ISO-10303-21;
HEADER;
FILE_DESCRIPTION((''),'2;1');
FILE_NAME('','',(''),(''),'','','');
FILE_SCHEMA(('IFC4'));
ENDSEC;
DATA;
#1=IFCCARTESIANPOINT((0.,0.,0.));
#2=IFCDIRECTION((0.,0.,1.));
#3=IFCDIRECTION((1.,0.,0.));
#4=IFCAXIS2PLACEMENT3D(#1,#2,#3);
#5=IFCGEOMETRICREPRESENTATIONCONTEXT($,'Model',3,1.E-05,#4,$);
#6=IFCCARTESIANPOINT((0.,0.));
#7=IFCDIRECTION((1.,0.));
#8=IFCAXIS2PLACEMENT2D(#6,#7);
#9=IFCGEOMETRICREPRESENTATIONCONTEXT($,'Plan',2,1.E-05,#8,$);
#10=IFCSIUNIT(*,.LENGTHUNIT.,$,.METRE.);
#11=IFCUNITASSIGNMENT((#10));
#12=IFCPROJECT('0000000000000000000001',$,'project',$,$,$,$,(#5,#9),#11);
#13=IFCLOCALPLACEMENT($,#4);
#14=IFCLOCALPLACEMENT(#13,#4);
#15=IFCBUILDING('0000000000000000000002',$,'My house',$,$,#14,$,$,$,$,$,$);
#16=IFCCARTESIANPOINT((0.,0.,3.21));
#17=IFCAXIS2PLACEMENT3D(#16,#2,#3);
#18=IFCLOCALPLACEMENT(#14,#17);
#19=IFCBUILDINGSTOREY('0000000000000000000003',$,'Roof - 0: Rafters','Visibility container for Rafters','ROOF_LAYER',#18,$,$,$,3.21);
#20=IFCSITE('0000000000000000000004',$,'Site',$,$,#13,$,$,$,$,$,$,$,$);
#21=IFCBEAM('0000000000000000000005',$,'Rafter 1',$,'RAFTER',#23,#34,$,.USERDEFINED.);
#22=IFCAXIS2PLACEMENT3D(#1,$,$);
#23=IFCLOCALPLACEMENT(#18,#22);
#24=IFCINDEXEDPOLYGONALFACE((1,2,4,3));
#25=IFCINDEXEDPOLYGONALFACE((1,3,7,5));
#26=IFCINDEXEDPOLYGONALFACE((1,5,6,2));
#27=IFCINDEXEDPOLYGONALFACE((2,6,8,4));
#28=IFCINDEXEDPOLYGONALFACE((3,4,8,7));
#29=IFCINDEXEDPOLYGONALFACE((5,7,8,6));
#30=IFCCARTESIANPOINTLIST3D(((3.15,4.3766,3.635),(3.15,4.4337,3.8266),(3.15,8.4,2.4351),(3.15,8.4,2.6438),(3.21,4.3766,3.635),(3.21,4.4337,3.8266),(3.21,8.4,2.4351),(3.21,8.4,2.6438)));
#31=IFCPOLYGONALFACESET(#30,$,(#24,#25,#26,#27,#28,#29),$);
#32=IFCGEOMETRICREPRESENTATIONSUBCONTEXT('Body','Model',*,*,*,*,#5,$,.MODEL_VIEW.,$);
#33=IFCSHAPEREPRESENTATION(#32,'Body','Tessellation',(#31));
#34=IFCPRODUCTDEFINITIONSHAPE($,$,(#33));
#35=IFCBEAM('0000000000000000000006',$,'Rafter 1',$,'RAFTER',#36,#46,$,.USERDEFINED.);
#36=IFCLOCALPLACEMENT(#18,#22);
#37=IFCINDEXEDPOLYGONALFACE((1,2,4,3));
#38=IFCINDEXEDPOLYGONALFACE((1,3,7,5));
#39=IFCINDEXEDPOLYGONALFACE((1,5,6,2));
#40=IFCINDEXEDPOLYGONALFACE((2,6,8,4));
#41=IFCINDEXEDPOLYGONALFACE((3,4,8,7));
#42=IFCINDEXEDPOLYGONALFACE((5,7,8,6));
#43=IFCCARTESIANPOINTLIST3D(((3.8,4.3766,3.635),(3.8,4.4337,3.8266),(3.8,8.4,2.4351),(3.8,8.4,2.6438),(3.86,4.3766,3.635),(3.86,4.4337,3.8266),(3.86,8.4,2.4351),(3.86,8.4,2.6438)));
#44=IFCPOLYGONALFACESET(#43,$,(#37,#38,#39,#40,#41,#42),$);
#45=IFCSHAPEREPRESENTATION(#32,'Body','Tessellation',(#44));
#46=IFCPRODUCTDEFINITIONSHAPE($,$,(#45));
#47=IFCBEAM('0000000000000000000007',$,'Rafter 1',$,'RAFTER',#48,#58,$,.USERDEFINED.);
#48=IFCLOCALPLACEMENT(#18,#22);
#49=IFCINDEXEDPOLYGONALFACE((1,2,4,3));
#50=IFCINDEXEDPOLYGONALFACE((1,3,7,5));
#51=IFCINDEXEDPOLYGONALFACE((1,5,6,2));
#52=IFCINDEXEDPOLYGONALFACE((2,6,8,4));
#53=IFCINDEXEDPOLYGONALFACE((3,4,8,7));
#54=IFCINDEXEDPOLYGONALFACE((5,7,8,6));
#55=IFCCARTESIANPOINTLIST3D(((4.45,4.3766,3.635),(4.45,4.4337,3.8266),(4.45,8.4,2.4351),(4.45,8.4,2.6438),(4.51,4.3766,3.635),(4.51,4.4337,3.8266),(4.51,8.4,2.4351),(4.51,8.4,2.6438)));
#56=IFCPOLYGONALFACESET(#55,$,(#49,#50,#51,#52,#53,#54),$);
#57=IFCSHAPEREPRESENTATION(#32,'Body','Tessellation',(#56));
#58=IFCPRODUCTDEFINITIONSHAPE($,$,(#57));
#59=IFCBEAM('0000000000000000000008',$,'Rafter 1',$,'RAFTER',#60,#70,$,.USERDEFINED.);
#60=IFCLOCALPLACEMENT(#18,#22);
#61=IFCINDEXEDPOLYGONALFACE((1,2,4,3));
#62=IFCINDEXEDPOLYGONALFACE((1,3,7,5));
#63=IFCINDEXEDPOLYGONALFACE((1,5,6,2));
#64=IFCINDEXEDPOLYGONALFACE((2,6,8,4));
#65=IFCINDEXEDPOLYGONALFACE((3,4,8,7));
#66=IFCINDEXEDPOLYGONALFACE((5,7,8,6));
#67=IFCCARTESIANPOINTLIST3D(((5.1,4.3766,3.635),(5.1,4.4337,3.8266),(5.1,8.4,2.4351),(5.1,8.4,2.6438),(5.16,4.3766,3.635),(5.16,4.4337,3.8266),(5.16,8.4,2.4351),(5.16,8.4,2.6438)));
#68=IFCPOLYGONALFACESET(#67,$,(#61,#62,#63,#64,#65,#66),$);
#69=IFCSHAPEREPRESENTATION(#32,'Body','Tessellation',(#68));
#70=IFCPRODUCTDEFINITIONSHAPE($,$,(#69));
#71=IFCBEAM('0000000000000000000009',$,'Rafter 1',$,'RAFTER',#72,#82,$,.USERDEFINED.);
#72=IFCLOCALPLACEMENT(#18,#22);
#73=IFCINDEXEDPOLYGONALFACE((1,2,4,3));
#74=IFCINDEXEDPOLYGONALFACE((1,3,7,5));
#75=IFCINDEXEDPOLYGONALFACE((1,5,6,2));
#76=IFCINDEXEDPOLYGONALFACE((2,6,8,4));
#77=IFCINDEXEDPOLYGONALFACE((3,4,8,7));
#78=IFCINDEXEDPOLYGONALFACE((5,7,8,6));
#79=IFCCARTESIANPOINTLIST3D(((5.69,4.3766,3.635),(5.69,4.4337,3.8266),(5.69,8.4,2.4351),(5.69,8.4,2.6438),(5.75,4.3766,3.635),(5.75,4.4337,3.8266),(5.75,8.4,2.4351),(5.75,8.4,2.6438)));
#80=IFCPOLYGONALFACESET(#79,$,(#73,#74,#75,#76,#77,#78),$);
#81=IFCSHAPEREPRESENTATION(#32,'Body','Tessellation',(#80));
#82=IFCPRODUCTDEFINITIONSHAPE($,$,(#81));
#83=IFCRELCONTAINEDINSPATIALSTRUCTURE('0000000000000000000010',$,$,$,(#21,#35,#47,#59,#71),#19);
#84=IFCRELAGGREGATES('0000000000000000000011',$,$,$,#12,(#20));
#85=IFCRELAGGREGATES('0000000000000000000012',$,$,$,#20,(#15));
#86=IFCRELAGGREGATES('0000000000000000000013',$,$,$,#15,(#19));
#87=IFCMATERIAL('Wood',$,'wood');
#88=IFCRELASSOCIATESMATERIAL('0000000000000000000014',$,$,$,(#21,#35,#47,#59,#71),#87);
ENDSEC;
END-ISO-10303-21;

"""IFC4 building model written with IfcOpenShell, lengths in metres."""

from ifc_helpers import new_model, si_unit, frame, origin_with_axes, origin_2d_with_axis, place, context, subcontext, project, spatial, rectangle, extrude, clip, halfspace, material, element, save


model = new_model("IFC4")

# Units and contexts
model_context = context("Model", 3, precision=1e-05, world=origin_with_axes())
plan_context = context("Plan", 2, precision=1e-05, world=origin_2d_with_axis())
body_context = subcontext(model_context, "Body", "Model", "MODEL_VIEW")
ifc_project = project(units=[si_unit("LENGTHUNIT", "METRE")], contexts=[model_context, plan_context])

# Site, building, storey
site_placement = place(None, origin_with_axes())
site = spatial("IfcSite", under=ifc_project, at=site_placement, Name="Site")
building_placement = place(site_placement, origin_with_axes())
building = spatial("IfcBuilding", under=site, at=building_placement, Name="My house")
storey_placement = place(building_placement, frame((0.0, 0.0, 3.21), z_axis=(0.0, 0.0, 1.0), x_axis=(1.0, 0.0, 0.0)))
storey = spatial("IfcBuildingStorey", under=building, at=storey_placement, Name="Roof - 0: Rafters", Description="Visibility container for Rafters", ObjectType="ROOF_LAYER", Elevation=3.21)

# Beams
ifc_material = material(Name="Wood", Category="wood")
beam_1_placement = place(storey_placement, frame((3.18, 4.4051, 3.7308), z_axis=(0.0, 0.28578, 0.958295), x_axis=(0.0, 0.958295, -0.28578)))
element("IfcBeam", 1, at=beam_1_placement, inside=storey, material=ifc_material, Name="Rafter 1", ObjectType="RAFTER", PredefinedType="USERDEFINED", context=body_context, shape_type="Clipping", body=[
    clip(clip(extrude(rectangle(XDim=0.06, YDim=0.2), frame((0.0, 0.0, 0.0), z_axis=(1.0, 0.0, 0.0), x_axis=(0.0, 1.0, 0.0)), (0.0, 0.0, 1.0), 5.5), halfspace(frame((1.5953, 3.18, -6.7671), z_axis=(-0.958295, 0.0, -0.28578), x_axis=(0.0, 1.0, 0.0)), False)), halfspace(frame((5.8118, 3.18, -5.5097), z_axis=(0.958295, 0.0, 0.28578), x_axis=(0.0, -1.0, 0.0)), False)),
])
beam_2_placement = place(storey_placement, frame((3.83, 4.4051, 3.7308), z_axis=(0.0, 0.28578, 0.958295), x_axis=(0.0, 0.958295, -0.28578)))
element("IfcBeam", 2, at=beam_2_placement, inside=storey, material=ifc_material, Name="Rafter 1", ObjectType="RAFTER", PredefinedType="USERDEFINED", context=body_context, shape_type="Clipping", body=[
    clip(clip(extrude(rectangle(XDim=0.06, YDim=0.2), frame((0.0, 0.0, 0.0), z_axis=(1.0, 0.0, 0.0), x_axis=(0.0, 1.0, 0.0)), (0.0, 0.0, 1.0), 5.5), halfspace(frame((1.5953, 3.83, -6.7671), z_axis=(-0.958295, 0.0, -0.28578), x_axis=(0.0, 1.0, 0.0)), False)), halfspace(frame((5.8118, 3.83, -5.5097), z_axis=(0.958295, 0.0, 0.28578), x_axis=(0.0, -1.0, 0.0)), False)),
])
beam_3_placement = place(storey_placement, frame((4.48, 4.4051, 3.7308), z_axis=(0.0, 0.28578, 0.958295), x_axis=(0.0, 0.958295, -0.28578)))
element("IfcBeam", 3, at=beam_3_placement, inside=storey, material=ifc_material, Name="Rafter 1", ObjectType="RAFTER", PredefinedType="USERDEFINED", context=body_context, shape_type="Clipping", body=[
    clip(clip(extrude(rectangle(XDim=0.06, YDim=0.2), frame((0.0, 0.0, 0.0), z_axis=(1.0, 0.0, 0.0), x_axis=(0.0, 1.0, 0.0)), (0.0, 0.0, 1.0), 5.5), halfspace(frame((1.5953, 4.48, -6.7671), z_axis=(-0.958295, 0.0, -0.28578), x_axis=(0.0, 1.0, 0.0)), False)), halfspace(frame((5.8118, 4.48, -5.5097), z_axis=(0.958295, 0.0, 0.28578), x_axis=(0.0, -1.0, 0.0)), False)),
])
beam_4_placement = place(storey_placement, frame((5.13, 4.4051, 3.7308), z_axis=(0.0, 0.28578, 0.958295), x_axis=(0.0, 0.958295, -0.28578)))
element("IfcBeam", 4, at=beam_4_placement, inside=storey, material=ifc_material, Name="Rafter 1", ObjectType="RAFTER", PredefinedType="USERDEFINED", context=body_context, shape_type="Clipping", body=[
    clip(clip(extrude(rectangle(XDim=0.06, YDim=0.2), frame((0.0, 0.0, 0.0), z_axis=(1.0, 0.0, 0.0), x_axis=(0.0, 1.0, 0.0)), (0.0, 0.0, 1.0), 5.5), halfspace(frame((1.5953, 5.13, -6.7671), z_axis=(-0.958295, 0.0, -0.28578), x_axis=(0.0, 1.0, 0.0)), False)), halfspace(frame((5.8118, 5.13, -5.5097), z_axis=(0.958295, 0.0, 0.28578), x_axis=(0.0, -1.0, 0.0)), False)),
])
beam_5_placement = place(storey_placement, frame((5.72, 4.4051, 3.7308), z_axis=(0.0, 0.28578, 0.958295), x_axis=(0.0, 0.958295, -0.28578)))
element("IfcBeam", 5, at=beam_5_placement, inside=storey, material=ifc_material, Name="Rafter 1", ObjectType="RAFTER", PredefinedType="USERDEFINED", context=body_context, shape_type="Clipping", body=[
    clip(clip(extrude(rectangle(XDim=0.06, YDim=0.2), frame((0.0, 0.0, 0.0), z_axis=(1.0, 0.0, 0.0), x_axis=(0.0, 1.0, 0.0)), (0.0, 0.0, 1.0), 5.5), halfspace(frame((1.5953, 5.72, -6.7671), z_axis=(-0.958295, 0.0, -0.28578), x_axis=(0.0, 1.0, 0.0)), False)), halfspace(frame((5.8118, 5.72, -5.5097), z_axis=(0.958295, 0.0, 0.28578), x_axis=(0.0, -1.0, 0.0)), False)),
])

save(model, "model.ifc")
